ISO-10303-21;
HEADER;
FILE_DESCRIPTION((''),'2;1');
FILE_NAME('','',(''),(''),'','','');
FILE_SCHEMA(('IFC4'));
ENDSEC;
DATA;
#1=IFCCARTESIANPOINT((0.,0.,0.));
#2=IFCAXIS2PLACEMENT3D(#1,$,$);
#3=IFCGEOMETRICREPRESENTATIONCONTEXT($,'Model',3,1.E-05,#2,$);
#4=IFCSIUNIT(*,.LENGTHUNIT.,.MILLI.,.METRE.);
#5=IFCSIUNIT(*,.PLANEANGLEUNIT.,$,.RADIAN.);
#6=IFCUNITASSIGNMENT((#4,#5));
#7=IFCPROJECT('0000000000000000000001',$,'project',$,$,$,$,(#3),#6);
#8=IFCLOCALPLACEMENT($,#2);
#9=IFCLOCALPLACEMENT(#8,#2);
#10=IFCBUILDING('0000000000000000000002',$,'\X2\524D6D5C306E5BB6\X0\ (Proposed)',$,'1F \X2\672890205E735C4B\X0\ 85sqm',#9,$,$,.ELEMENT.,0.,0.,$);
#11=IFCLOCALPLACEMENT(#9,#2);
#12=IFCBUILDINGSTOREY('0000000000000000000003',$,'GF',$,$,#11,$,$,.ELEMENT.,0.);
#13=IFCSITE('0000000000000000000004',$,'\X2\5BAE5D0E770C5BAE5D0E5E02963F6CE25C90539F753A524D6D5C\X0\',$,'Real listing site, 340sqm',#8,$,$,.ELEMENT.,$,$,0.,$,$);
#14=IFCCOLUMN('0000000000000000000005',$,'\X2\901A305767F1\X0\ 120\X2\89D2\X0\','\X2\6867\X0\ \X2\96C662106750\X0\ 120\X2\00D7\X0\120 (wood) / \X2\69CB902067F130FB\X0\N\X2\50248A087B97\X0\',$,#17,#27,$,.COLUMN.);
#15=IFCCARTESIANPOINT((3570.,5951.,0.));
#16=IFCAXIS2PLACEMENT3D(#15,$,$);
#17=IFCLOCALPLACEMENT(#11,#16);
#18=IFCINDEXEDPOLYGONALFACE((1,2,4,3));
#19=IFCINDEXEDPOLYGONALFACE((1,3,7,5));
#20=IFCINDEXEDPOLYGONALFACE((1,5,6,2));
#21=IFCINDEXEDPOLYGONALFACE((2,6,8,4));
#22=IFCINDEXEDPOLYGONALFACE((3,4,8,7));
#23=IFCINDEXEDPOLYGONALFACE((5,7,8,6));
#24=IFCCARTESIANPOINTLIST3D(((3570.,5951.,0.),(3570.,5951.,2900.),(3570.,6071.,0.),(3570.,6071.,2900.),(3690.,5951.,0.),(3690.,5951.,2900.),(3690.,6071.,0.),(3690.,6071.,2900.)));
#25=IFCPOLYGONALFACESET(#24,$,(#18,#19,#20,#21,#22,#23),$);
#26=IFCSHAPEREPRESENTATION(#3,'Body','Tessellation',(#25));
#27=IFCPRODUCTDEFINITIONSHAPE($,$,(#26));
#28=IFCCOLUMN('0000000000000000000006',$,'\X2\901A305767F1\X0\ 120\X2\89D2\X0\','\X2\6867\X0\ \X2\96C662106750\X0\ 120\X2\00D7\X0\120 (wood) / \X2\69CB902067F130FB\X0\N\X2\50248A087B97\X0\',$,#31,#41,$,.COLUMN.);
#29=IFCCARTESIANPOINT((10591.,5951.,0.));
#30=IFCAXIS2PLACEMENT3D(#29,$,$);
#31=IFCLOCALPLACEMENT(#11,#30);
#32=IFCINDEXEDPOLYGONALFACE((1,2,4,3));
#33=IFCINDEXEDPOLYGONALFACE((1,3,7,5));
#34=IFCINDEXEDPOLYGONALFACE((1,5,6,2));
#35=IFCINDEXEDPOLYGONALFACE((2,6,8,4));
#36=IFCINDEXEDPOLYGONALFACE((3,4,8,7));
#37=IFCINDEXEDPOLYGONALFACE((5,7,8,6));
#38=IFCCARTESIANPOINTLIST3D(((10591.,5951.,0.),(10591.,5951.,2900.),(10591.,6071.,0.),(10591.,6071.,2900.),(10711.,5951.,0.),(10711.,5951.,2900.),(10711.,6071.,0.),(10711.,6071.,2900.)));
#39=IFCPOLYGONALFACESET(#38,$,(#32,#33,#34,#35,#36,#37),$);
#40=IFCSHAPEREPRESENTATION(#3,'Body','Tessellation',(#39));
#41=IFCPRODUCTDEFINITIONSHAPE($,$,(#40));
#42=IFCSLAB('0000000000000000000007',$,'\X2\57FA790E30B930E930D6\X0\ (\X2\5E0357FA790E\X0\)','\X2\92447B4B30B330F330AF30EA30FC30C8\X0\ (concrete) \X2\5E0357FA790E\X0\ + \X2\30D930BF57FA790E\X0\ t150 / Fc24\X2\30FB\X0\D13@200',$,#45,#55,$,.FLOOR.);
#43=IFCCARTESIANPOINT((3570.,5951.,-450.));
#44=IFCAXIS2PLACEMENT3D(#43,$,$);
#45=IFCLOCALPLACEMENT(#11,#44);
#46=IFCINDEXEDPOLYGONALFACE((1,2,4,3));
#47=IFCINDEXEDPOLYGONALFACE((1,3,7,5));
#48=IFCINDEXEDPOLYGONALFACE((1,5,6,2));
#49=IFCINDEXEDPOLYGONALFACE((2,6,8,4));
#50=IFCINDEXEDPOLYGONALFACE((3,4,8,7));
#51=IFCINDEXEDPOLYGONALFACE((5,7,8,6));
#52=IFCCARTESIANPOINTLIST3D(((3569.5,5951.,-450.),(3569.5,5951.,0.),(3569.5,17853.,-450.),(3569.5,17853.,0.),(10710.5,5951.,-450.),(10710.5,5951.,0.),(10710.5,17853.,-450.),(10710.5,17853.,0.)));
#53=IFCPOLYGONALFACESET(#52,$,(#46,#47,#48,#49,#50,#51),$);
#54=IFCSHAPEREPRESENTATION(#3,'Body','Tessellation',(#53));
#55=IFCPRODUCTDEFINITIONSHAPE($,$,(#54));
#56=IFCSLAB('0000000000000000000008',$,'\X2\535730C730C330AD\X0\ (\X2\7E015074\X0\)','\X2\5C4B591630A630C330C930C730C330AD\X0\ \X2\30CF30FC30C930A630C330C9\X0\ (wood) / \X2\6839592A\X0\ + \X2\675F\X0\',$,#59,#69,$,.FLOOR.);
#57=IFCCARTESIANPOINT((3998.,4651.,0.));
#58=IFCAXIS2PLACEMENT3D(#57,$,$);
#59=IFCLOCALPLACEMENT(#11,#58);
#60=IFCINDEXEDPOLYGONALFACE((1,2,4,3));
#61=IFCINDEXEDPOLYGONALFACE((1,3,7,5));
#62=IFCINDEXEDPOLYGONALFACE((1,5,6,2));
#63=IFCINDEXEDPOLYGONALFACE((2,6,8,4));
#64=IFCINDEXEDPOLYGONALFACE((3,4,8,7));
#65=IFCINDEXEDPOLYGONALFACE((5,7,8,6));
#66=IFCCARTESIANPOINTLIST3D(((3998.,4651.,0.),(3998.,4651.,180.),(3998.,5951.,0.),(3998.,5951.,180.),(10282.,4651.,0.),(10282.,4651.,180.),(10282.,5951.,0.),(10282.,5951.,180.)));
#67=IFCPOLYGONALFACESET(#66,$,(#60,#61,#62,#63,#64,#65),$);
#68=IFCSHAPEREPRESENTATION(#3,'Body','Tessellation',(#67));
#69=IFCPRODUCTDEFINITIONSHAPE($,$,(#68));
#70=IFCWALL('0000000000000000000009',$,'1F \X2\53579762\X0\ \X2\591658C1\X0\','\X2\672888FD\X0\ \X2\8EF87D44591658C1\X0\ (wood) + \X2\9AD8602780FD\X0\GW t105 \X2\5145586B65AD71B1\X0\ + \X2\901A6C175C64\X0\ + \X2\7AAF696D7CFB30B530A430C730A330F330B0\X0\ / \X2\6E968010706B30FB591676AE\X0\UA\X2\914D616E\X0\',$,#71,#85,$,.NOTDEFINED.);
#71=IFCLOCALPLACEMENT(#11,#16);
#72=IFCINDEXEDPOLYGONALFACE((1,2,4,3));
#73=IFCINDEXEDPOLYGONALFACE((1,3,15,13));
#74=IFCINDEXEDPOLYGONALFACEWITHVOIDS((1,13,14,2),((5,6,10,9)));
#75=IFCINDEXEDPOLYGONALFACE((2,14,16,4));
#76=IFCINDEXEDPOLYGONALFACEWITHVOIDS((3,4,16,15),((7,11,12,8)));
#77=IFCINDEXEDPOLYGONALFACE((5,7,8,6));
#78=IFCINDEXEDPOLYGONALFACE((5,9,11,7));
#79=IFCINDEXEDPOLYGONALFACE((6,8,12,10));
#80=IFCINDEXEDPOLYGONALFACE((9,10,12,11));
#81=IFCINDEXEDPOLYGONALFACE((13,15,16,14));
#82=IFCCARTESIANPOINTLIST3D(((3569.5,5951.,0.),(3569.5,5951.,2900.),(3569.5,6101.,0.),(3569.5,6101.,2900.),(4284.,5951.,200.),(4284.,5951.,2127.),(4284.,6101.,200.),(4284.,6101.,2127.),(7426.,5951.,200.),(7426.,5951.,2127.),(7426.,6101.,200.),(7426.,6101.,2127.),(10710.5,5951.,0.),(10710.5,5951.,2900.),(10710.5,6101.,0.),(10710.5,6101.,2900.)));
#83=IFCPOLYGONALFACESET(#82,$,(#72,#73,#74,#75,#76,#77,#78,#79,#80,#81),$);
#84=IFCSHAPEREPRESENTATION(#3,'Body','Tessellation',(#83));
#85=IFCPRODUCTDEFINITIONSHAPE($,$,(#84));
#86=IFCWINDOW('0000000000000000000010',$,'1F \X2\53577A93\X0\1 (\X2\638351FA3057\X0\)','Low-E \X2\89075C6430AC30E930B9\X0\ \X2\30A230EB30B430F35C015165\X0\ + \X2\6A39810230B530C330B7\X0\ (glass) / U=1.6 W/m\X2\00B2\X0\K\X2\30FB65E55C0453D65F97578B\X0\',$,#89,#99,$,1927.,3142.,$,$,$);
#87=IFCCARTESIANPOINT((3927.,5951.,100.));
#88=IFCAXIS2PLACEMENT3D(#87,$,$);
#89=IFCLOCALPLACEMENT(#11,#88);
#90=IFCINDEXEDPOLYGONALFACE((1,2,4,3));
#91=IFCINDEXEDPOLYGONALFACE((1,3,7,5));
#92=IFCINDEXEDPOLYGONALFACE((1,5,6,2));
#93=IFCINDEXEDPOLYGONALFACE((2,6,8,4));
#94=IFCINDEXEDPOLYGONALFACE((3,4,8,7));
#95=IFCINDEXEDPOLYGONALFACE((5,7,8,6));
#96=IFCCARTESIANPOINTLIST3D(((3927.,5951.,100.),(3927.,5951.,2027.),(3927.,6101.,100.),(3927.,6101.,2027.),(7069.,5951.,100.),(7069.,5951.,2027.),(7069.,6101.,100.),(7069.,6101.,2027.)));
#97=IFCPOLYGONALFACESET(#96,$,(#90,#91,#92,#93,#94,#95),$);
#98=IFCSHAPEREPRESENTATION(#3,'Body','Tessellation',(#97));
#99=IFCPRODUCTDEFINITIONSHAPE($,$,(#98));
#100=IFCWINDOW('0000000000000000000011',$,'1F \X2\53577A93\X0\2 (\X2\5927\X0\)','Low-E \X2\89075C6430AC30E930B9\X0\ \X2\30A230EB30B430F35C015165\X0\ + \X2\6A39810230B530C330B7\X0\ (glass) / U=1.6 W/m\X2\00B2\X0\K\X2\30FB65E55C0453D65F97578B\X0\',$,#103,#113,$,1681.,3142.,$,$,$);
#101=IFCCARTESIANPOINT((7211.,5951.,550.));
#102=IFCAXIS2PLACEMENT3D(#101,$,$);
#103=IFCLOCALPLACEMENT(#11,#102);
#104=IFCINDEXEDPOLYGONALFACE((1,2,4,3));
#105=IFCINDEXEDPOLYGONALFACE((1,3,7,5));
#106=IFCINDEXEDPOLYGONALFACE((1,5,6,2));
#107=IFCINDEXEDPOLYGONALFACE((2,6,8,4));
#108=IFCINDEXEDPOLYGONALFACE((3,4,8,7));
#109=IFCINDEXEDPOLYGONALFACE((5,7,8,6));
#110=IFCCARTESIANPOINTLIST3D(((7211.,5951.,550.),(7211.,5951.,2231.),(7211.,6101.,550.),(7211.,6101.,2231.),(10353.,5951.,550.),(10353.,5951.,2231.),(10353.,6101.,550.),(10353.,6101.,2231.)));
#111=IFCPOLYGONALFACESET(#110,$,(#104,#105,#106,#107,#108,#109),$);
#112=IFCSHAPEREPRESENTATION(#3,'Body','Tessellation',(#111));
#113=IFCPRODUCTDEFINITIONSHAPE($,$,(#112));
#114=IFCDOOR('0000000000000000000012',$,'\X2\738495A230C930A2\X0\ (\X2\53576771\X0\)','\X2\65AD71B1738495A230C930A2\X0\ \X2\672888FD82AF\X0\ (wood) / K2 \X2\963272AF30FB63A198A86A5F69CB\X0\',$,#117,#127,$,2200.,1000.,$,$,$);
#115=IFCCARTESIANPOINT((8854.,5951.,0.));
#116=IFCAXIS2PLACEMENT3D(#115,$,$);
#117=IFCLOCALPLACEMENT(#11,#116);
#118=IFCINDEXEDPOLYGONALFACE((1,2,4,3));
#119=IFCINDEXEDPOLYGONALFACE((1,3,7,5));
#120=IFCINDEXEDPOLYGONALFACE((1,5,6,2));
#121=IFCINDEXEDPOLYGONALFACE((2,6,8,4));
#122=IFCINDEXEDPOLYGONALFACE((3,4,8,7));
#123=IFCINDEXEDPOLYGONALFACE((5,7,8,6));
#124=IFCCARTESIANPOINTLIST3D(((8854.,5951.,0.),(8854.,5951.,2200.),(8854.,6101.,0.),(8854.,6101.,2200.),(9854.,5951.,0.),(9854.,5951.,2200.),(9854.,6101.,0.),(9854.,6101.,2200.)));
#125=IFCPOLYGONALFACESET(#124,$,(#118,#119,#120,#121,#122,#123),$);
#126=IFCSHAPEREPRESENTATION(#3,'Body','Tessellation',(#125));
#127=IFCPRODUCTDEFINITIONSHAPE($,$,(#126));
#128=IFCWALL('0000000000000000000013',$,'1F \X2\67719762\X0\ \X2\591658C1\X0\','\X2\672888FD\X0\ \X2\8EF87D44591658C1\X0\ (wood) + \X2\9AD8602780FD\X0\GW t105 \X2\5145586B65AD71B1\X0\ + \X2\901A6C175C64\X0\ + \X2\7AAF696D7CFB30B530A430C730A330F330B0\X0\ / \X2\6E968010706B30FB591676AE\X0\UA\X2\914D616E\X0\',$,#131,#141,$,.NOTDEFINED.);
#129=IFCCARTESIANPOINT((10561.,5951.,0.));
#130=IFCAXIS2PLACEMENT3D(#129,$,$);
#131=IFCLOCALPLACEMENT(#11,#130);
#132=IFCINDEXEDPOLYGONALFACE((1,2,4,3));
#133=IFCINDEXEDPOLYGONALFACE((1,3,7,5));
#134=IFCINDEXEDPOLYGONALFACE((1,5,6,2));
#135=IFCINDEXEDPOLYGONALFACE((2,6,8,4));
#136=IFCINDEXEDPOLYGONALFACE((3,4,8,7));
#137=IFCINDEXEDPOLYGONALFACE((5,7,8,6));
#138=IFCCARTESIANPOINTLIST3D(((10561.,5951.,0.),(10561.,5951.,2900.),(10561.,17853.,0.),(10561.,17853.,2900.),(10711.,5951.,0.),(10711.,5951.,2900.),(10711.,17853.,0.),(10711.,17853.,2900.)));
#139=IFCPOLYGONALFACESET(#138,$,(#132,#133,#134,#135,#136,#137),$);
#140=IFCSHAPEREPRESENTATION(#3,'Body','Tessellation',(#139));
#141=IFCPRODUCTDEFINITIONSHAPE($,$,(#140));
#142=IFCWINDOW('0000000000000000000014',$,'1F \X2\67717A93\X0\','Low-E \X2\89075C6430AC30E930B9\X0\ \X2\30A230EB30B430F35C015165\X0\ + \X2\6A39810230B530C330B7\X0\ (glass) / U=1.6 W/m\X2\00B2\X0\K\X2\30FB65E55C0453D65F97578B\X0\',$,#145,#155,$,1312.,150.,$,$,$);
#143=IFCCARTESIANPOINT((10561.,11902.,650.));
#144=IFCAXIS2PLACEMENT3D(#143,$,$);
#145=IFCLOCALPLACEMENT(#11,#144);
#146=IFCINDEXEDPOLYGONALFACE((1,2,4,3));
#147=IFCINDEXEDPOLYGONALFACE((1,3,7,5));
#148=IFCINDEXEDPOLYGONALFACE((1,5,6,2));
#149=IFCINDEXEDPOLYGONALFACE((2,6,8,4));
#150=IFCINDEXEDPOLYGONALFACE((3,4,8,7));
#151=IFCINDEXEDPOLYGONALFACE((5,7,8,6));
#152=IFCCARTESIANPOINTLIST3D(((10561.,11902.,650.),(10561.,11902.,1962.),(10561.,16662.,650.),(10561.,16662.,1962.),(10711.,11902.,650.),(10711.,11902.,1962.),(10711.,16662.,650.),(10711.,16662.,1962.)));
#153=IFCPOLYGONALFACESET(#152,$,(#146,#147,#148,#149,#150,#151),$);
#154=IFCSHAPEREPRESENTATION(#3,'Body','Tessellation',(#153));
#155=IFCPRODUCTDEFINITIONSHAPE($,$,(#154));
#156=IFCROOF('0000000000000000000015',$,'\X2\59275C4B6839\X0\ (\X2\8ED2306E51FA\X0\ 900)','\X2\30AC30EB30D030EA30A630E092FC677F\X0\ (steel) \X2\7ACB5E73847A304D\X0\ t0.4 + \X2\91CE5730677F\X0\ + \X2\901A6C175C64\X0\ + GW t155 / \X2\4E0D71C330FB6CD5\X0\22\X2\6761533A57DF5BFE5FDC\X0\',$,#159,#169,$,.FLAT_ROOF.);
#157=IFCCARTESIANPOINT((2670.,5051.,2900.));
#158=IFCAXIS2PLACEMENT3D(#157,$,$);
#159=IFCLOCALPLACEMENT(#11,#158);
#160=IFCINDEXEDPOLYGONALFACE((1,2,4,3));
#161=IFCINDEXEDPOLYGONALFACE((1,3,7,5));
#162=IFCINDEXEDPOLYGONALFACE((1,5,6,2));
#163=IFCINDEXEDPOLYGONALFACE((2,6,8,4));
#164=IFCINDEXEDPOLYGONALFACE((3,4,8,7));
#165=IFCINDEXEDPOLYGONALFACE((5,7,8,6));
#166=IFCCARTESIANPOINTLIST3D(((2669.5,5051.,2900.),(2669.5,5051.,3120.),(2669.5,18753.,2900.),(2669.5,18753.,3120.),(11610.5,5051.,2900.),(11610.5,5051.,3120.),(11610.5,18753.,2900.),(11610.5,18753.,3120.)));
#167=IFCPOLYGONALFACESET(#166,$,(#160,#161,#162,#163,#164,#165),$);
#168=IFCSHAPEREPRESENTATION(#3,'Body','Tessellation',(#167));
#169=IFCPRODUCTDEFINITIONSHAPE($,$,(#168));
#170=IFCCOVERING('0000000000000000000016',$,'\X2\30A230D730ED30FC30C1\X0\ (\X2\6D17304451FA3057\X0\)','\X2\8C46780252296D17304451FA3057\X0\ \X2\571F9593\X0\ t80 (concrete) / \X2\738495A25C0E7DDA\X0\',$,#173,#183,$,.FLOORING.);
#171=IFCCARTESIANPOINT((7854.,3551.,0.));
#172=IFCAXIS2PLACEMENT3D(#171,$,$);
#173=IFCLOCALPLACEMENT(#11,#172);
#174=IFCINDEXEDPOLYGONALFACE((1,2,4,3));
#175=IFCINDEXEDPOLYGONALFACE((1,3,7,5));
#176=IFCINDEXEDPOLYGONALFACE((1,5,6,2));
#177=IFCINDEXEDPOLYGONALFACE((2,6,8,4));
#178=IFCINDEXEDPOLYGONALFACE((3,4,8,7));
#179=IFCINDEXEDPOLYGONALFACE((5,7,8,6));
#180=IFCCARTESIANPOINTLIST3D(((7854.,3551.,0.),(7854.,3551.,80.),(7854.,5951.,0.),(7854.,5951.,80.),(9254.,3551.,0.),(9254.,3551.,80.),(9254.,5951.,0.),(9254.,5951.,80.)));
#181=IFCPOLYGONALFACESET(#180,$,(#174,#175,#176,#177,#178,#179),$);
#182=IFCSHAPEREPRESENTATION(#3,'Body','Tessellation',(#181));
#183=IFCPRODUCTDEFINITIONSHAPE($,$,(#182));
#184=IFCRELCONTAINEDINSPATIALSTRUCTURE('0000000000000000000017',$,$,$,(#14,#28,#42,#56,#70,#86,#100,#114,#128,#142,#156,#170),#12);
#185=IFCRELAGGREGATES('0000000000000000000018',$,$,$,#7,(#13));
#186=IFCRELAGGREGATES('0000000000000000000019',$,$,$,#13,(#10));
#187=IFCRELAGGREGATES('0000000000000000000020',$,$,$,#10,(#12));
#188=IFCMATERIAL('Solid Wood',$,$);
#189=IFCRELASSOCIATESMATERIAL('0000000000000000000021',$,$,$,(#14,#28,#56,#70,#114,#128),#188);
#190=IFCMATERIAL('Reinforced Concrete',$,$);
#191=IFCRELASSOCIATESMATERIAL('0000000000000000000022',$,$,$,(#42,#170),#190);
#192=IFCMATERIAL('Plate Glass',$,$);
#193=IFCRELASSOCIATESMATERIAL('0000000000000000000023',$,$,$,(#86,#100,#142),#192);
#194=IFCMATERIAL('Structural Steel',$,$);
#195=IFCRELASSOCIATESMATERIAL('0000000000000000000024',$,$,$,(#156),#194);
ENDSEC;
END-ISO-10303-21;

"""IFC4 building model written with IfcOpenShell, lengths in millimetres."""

from ifc_helpers import new_model, si_unit, frame, frame_2d, origin, place, context, project, spatial, rectangle, extrude, material, element, fill, save


model = new_model("IFC4")

# Units and contexts
model_context = context("Model", 3, precision=1e-05, world=origin())
ifc_project = project(units=[si_unit("LENGTHUNIT", "METRE", prefix="MILLI"), si_unit("PLANEANGLEUNIT", "RADIAN")], contexts=[model_context])

# Site, building, storey
site_placement = place(None, origin())
site = spatial("IfcSite", under=ifc_project, at=site_placement, Name="宮崎県宮崎市阿波岐原町前浜", ObjectType="Real listing site, 340sqm", CompositionType="ELEMENT", RefElevation=0.0)
building_placement = place(site_placement, origin())
building = spatial("IfcBuilding", under=site, at=building_placement, Name="前浜の家 (Proposed)", ObjectType="1F 木造平屋 85sqm", CompositionType="ELEMENT", ElevationOfRefHeight=0.0, ElevationOfTerrain=0.0)
storey_placement = place(building_placement, origin())
storey = spatial("IfcBuildingStorey", under=building, at=storey_placement, Name="GF", CompositionType="ELEMENT", Elevation=0.0)

# Columns
ifc_material_1 = material(Name="Solid Wood")
column_1_placement = place(storey_placement, frame((3570.0, 5951.0, 0.0)))
element("IfcColumn", 1, at=column_1_placement, inside=storey, material=ifc_material_1, Name="通し柱 120角", Description="桧 集成材 120×120 (wood) / 構造柱・N値計算", PredefinedType="COLUMN", context=model_context, shape_type="SweptSolid", body=[
    extrude(rectangle(XDim=120.0, YDim=120.0, at=frame_2d((60.0, 60.0))), frame((3570.0, 5951.0, 0.0)), (0.0, 0.0, 1.0), 2900.0),
])
column_2_placement = place(storey_placement, frame((10591.0, 5951.0, 0.0)))
element("IfcColumn", 2, at=column_2_placement, inside=storey, material=ifc_material_1, Name="通し柱 120角", Description="桧 集成材 120×120 (wood) / 構造柱・N値計算", PredefinedType="COLUMN", context=model_context, shape_type="SweptSolid", body=[
    extrude(rectangle(XDim=120.0, YDim=120.0, at=frame_2d((60.0, 60.0))), frame((10591.0, 5951.0, 0.0)), (0.0, 0.0, 1.0), 2900.0),
])

# Slabs
ifc_material_2 = material(Name="Reinforced Concrete")
slab_1_placement = place(storey_placement, frame((3570.0, 5951.0, -450.0)))
element("IfcSlab", 3, at=slab_1_placement, inside=storey, material=ifc_material_2, Name="基礎スラブ (布基礎)", Description="鉄筋コンクリート (concrete) 布基礎 + ベタ基礎 t150 / Fc24・D13@200", PredefinedType="FLOOR", context=model_context, shape_type="SweptSolid", body=[
    extrude(rectangle(XDim=7141.0, YDim=11902.0, at=frame_2d((3570.0, 5951.0))), frame((3570.0, 5951.0, -450.0)), (0.0, 0.0, 1.0), 450.0),
])
slab_2_placement = place(storey_placement, frame((3998.0, 4651.0, 0.0)))
element("IfcSlab", 4, at=slab_2_placement, inside=storey, material=ifc_material_1, Name="南デッキ (縁側)", Description="屋外ウッドデッキ ハードウッド (wood) / 根太 + 束", PredefinedType="FLOOR", context=model_context, shape_type="SweptSolid", body=[
    extrude(rectangle(XDim=6284.0, YDim=1300.0, at=frame_2d((3142.0, 650.0))), frame((3998.0, 4651.0, 0.0)), (0.0, 0.0, 1.0), 180.0),
])

# Wall, openings, windows, door
wall_1_placement = place(storey_placement, frame((3570.0, 5951.0, 0.0)))
wall_1 = element("IfcWall", 5, at=wall_1_placement, inside=storey, material=ifc_material_1, Name="1F 南面 外壁", Description="木製 軸組外壁 (wood) + 高性能GW t105 充填断熱 + 通気層 + 窯業系サイディング / 準耐火・外皮UA配慮", PredefinedType="NOTDEFINED", context=model_context, shape_type="SweptSolid", body=[
    extrude(rectangle(XDim=7141.0, YDim=150.0, at=frame_2d((3570.0, 75.0))), frame((3570.0, 5951.0, 0.0)), (0.0, 0.0, 1.0), 2900.0),
])
opening_1_placement = place(storey_placement, frame((3927.0, 5951.0, 100.0)))
opening_1 = element("IfcOpeningElement", 6, at=opening_1_placement, cuts=wall_1, PredefinedType="NOTDEFINED", context=model_context, shape_type="SweptSolid", body=[
    extrude(rectangle(XDim=3142.0, YDim=150.0, at=frame_2d((1571.0, 75.0))), frame((3927.0, 5951.0, 100.0)), (0.0, 0.0, 1.0), 1927.0),
])
opening_2_placement = place(storey_placement, frame((7211.0, 5951.0, 550.0)))
opening_2 = element("IfcOpeningElement", 7, at=opening_2_placement, cuts=wall_1, PredefinedType="NOTDEFINED", context=model_context, shape_type="SweptSolid", body=[
    extrude(rectangle(XDim=3142.0, YDim=150.0, at=frame_2d((1571.0, 75.0))), frame((7211.0, 5951.0, 550.0)), (0.0, 0.0, 1.0), 1681.0),
])
opening_3_placement = place(storey_placement, frame((8854.0, 5951.0, 0.0)))
opening_3 = element("IfcOpeningElement", 8, at=opening_3_placement, cuts=wall_1, PredefinedType="NOTDEFINED", context=model_context, shape_type="SweptSolid", body=[
    extrude(rectangle(XDim=1000.0, YDim=150.0, at=frame_2d((500.0, 75.0))), frame((8854.0, 5951.0, 0.0)), (0.0, 0.0, 1.0), 2200.0),
])
ifc_material_3 = material(Name="Plate Glass")
window_1_placement = place(storey_placement, frame((3927.0, 5951.0, 100.0)))
window_1 = element("IfcWindow", 9, at=window_1_placement, inside=storey, material=ifc_material_3, Name="1F 南窓1 (掃出し)", Description="Low-E 複層ガラス アルゴン封入 + 樹脂サッシ (glass) / U=1.6 W/m²K・日射取得型", OverallHeight=1927.0, OverallWidth=3142.0, context=model_context, shape_type="SweptSolid", body=[
    extrude(rectangle(XDim=3142.0, YDim=150.0, at=frame_2d((1571.0, 75.0))), frame((3927.0, 5951.0, 100.0)), (0.0, 0.0, 1.0), 1927.0),
])
fill(opening_1, window_1)
window_2_placement = place(storey_placement, frame((7211.0, 5951.0, 550.0)))
window_2 = element("IfcWindow", 10, at=window_2_placement, inside=storey, material=ifc_material_3, Name="1F 南窓2 (大)", Description="Low-E 複層ガラス アルゴン封入 + 樹脂サッシ (glass) / U=1.6 W/m²K・日射取得型", OverallHeight=1681.0, OverallWidth=3142.0, context=model_context, shape_type="SweptSolid", body=[
    extrude(rectangle(XDim=3142.0, YDim=150.0, at=frame_2d((1571.0, 75.0))), frame((7211.0, 5951.0, 550.0)), (0.0, 0.0, 1.0), 1681.0),
])
fill(opening_2, window_2)
door_placement = place(storey_placement, frame((8854.0, 5951.0, 0.0)))
door = element("IfcDoor", 11, at=door_placement, inside=storey, material=ifc_material_1, Name="玄関ドア (南東)", Description="断熱玄関ドア 木製芯 (wood) / K2 防犯・採風機構", OverallHeight=2200.0, OverallWidth=1000.0, context=model_context, shape_type="SweptSolid", body=[
    extrude(rectangle(XDim=1000.0, YDim=150.0, at=frame_2d((500.0, 75.0))), frame((8854.0, 5951.0, 0.0)), (0.0, 0.0, 1.0), 2200.0),
])
fill(opening_3, door)

# Wall, opening, window
wall_2_placement = place(storey_placement, frame((10561.0, 5951.0, 0.0)))
wall_2 = element("IfcWall", 12, at=wall_2_placement, inside=storey, material=ifc_material_1, Name="1F 東面 外壁", Description="木製 軸組外壁 (wood) + 高性能GW t105 充填断熱 + 通気層 + 窯業系サイディング / 準耐火・外皮UA配慮", PredefinedType="NOTDEFINED", context=model_context, shape_type="SweptSolid", body=[
    extrude(rectangle(XDim=150.0, YDim=11902.0, at=frame_2d((75.0, 5951.0))), frame((10561.0, 5951.0, 0.0)), (0.0, 0.0, 1.0), 2900.0),
])
opening_4_placement = place(storey_placement, frame((10561.0, 11902.0, 650.0)))
opening_4 = element("IfcOpeningElement", 13, at=opening_4_placement, cuts=wall_2, PredefinedType="NOTDEFINED", context=model_context, shape_type="SweptSolid", body=[
    extrude(rectangle(XDim=150.0, YDim=4760.0, at=frame_2d((75.0, 2380.0))), frame((10561.0, 11902.0, 650.0)), (0.0, 0.0, 1.0), 1312.0),
])
window_3_placement = place(storey_placement, frame((10561.0, 11902.0, 650.0)))
window_3 = element("IfcWindow", 14, at=window_3_placement, inside=storey, material=ifc_material_3, Name="1F 東窓", Description="Low-E 複層ガラス アルゴン封入 + 樹脂サッシ (glass) / U=1.6 W/m²K・日射取得型", OverallHeight=1312.0, OverallWidth=150.0, context=model_context, shape_type="SweptSolid", body=[
    extrude(rectangle(XDim=150.0, YDim=4760.0, at=frame_2d((75.0, 2380.0))), frame((10561.0, 11902.0, 650.0)), (0.0, 0.0, 1.0), 1312.0),
])
fill(opening_4, window_3)

# Roof
ifc_material_4 = material(Name="Structural Steel")
roof_placement = place(storey_placement, frame((2670.0, 5051.0, 2900.0)))
element("IfcRoof", 15, at=roof_placement, inside=storey, material=ifc_material_4, Name="大屋根 (軒の出 900)", Description="ガルバリウム鋼板 (steel) 立平葺き t0.4 + 野地板 + 通気層 + GW t155 / 不燃・法22条区域対応", PredefinedType="FLAT_ROOF", context=model_context, shape_type="SweptSolid", body=[
    extrude(rectangle(XDim=8941.0, YDim=13702.0, at=frame_2d((4470.0, 6851.0))), frame((2670.0, 5051.0, 2900.0)), (0.0, 0.0, 1.0), 220.0),
])

# Covering
covering_1_placement = place(storey_placement, frame((7854.0, 3551.0, 0.0)))
element("IfcCovering", 16, at=covering_1_placement, inside=storey, material=ifc_material_2, Name="アプローチ (洗い出し)", Description="豆砂利洗い出し 土間 t80 (concrete) / 玄関導線", PredefinedType="FLOORING", context=model_context, shape_type="SweptSolid", body=[
    extrude(rectangle(XDim=1400.0, YDim=2400.0, at=frame_2d((700.0, 1200.0))), frame((7854.0, 3551.0, 0.0)), (0.0, 0.0, 1.0), 80.0),
])

save(model, "model.ifc")
